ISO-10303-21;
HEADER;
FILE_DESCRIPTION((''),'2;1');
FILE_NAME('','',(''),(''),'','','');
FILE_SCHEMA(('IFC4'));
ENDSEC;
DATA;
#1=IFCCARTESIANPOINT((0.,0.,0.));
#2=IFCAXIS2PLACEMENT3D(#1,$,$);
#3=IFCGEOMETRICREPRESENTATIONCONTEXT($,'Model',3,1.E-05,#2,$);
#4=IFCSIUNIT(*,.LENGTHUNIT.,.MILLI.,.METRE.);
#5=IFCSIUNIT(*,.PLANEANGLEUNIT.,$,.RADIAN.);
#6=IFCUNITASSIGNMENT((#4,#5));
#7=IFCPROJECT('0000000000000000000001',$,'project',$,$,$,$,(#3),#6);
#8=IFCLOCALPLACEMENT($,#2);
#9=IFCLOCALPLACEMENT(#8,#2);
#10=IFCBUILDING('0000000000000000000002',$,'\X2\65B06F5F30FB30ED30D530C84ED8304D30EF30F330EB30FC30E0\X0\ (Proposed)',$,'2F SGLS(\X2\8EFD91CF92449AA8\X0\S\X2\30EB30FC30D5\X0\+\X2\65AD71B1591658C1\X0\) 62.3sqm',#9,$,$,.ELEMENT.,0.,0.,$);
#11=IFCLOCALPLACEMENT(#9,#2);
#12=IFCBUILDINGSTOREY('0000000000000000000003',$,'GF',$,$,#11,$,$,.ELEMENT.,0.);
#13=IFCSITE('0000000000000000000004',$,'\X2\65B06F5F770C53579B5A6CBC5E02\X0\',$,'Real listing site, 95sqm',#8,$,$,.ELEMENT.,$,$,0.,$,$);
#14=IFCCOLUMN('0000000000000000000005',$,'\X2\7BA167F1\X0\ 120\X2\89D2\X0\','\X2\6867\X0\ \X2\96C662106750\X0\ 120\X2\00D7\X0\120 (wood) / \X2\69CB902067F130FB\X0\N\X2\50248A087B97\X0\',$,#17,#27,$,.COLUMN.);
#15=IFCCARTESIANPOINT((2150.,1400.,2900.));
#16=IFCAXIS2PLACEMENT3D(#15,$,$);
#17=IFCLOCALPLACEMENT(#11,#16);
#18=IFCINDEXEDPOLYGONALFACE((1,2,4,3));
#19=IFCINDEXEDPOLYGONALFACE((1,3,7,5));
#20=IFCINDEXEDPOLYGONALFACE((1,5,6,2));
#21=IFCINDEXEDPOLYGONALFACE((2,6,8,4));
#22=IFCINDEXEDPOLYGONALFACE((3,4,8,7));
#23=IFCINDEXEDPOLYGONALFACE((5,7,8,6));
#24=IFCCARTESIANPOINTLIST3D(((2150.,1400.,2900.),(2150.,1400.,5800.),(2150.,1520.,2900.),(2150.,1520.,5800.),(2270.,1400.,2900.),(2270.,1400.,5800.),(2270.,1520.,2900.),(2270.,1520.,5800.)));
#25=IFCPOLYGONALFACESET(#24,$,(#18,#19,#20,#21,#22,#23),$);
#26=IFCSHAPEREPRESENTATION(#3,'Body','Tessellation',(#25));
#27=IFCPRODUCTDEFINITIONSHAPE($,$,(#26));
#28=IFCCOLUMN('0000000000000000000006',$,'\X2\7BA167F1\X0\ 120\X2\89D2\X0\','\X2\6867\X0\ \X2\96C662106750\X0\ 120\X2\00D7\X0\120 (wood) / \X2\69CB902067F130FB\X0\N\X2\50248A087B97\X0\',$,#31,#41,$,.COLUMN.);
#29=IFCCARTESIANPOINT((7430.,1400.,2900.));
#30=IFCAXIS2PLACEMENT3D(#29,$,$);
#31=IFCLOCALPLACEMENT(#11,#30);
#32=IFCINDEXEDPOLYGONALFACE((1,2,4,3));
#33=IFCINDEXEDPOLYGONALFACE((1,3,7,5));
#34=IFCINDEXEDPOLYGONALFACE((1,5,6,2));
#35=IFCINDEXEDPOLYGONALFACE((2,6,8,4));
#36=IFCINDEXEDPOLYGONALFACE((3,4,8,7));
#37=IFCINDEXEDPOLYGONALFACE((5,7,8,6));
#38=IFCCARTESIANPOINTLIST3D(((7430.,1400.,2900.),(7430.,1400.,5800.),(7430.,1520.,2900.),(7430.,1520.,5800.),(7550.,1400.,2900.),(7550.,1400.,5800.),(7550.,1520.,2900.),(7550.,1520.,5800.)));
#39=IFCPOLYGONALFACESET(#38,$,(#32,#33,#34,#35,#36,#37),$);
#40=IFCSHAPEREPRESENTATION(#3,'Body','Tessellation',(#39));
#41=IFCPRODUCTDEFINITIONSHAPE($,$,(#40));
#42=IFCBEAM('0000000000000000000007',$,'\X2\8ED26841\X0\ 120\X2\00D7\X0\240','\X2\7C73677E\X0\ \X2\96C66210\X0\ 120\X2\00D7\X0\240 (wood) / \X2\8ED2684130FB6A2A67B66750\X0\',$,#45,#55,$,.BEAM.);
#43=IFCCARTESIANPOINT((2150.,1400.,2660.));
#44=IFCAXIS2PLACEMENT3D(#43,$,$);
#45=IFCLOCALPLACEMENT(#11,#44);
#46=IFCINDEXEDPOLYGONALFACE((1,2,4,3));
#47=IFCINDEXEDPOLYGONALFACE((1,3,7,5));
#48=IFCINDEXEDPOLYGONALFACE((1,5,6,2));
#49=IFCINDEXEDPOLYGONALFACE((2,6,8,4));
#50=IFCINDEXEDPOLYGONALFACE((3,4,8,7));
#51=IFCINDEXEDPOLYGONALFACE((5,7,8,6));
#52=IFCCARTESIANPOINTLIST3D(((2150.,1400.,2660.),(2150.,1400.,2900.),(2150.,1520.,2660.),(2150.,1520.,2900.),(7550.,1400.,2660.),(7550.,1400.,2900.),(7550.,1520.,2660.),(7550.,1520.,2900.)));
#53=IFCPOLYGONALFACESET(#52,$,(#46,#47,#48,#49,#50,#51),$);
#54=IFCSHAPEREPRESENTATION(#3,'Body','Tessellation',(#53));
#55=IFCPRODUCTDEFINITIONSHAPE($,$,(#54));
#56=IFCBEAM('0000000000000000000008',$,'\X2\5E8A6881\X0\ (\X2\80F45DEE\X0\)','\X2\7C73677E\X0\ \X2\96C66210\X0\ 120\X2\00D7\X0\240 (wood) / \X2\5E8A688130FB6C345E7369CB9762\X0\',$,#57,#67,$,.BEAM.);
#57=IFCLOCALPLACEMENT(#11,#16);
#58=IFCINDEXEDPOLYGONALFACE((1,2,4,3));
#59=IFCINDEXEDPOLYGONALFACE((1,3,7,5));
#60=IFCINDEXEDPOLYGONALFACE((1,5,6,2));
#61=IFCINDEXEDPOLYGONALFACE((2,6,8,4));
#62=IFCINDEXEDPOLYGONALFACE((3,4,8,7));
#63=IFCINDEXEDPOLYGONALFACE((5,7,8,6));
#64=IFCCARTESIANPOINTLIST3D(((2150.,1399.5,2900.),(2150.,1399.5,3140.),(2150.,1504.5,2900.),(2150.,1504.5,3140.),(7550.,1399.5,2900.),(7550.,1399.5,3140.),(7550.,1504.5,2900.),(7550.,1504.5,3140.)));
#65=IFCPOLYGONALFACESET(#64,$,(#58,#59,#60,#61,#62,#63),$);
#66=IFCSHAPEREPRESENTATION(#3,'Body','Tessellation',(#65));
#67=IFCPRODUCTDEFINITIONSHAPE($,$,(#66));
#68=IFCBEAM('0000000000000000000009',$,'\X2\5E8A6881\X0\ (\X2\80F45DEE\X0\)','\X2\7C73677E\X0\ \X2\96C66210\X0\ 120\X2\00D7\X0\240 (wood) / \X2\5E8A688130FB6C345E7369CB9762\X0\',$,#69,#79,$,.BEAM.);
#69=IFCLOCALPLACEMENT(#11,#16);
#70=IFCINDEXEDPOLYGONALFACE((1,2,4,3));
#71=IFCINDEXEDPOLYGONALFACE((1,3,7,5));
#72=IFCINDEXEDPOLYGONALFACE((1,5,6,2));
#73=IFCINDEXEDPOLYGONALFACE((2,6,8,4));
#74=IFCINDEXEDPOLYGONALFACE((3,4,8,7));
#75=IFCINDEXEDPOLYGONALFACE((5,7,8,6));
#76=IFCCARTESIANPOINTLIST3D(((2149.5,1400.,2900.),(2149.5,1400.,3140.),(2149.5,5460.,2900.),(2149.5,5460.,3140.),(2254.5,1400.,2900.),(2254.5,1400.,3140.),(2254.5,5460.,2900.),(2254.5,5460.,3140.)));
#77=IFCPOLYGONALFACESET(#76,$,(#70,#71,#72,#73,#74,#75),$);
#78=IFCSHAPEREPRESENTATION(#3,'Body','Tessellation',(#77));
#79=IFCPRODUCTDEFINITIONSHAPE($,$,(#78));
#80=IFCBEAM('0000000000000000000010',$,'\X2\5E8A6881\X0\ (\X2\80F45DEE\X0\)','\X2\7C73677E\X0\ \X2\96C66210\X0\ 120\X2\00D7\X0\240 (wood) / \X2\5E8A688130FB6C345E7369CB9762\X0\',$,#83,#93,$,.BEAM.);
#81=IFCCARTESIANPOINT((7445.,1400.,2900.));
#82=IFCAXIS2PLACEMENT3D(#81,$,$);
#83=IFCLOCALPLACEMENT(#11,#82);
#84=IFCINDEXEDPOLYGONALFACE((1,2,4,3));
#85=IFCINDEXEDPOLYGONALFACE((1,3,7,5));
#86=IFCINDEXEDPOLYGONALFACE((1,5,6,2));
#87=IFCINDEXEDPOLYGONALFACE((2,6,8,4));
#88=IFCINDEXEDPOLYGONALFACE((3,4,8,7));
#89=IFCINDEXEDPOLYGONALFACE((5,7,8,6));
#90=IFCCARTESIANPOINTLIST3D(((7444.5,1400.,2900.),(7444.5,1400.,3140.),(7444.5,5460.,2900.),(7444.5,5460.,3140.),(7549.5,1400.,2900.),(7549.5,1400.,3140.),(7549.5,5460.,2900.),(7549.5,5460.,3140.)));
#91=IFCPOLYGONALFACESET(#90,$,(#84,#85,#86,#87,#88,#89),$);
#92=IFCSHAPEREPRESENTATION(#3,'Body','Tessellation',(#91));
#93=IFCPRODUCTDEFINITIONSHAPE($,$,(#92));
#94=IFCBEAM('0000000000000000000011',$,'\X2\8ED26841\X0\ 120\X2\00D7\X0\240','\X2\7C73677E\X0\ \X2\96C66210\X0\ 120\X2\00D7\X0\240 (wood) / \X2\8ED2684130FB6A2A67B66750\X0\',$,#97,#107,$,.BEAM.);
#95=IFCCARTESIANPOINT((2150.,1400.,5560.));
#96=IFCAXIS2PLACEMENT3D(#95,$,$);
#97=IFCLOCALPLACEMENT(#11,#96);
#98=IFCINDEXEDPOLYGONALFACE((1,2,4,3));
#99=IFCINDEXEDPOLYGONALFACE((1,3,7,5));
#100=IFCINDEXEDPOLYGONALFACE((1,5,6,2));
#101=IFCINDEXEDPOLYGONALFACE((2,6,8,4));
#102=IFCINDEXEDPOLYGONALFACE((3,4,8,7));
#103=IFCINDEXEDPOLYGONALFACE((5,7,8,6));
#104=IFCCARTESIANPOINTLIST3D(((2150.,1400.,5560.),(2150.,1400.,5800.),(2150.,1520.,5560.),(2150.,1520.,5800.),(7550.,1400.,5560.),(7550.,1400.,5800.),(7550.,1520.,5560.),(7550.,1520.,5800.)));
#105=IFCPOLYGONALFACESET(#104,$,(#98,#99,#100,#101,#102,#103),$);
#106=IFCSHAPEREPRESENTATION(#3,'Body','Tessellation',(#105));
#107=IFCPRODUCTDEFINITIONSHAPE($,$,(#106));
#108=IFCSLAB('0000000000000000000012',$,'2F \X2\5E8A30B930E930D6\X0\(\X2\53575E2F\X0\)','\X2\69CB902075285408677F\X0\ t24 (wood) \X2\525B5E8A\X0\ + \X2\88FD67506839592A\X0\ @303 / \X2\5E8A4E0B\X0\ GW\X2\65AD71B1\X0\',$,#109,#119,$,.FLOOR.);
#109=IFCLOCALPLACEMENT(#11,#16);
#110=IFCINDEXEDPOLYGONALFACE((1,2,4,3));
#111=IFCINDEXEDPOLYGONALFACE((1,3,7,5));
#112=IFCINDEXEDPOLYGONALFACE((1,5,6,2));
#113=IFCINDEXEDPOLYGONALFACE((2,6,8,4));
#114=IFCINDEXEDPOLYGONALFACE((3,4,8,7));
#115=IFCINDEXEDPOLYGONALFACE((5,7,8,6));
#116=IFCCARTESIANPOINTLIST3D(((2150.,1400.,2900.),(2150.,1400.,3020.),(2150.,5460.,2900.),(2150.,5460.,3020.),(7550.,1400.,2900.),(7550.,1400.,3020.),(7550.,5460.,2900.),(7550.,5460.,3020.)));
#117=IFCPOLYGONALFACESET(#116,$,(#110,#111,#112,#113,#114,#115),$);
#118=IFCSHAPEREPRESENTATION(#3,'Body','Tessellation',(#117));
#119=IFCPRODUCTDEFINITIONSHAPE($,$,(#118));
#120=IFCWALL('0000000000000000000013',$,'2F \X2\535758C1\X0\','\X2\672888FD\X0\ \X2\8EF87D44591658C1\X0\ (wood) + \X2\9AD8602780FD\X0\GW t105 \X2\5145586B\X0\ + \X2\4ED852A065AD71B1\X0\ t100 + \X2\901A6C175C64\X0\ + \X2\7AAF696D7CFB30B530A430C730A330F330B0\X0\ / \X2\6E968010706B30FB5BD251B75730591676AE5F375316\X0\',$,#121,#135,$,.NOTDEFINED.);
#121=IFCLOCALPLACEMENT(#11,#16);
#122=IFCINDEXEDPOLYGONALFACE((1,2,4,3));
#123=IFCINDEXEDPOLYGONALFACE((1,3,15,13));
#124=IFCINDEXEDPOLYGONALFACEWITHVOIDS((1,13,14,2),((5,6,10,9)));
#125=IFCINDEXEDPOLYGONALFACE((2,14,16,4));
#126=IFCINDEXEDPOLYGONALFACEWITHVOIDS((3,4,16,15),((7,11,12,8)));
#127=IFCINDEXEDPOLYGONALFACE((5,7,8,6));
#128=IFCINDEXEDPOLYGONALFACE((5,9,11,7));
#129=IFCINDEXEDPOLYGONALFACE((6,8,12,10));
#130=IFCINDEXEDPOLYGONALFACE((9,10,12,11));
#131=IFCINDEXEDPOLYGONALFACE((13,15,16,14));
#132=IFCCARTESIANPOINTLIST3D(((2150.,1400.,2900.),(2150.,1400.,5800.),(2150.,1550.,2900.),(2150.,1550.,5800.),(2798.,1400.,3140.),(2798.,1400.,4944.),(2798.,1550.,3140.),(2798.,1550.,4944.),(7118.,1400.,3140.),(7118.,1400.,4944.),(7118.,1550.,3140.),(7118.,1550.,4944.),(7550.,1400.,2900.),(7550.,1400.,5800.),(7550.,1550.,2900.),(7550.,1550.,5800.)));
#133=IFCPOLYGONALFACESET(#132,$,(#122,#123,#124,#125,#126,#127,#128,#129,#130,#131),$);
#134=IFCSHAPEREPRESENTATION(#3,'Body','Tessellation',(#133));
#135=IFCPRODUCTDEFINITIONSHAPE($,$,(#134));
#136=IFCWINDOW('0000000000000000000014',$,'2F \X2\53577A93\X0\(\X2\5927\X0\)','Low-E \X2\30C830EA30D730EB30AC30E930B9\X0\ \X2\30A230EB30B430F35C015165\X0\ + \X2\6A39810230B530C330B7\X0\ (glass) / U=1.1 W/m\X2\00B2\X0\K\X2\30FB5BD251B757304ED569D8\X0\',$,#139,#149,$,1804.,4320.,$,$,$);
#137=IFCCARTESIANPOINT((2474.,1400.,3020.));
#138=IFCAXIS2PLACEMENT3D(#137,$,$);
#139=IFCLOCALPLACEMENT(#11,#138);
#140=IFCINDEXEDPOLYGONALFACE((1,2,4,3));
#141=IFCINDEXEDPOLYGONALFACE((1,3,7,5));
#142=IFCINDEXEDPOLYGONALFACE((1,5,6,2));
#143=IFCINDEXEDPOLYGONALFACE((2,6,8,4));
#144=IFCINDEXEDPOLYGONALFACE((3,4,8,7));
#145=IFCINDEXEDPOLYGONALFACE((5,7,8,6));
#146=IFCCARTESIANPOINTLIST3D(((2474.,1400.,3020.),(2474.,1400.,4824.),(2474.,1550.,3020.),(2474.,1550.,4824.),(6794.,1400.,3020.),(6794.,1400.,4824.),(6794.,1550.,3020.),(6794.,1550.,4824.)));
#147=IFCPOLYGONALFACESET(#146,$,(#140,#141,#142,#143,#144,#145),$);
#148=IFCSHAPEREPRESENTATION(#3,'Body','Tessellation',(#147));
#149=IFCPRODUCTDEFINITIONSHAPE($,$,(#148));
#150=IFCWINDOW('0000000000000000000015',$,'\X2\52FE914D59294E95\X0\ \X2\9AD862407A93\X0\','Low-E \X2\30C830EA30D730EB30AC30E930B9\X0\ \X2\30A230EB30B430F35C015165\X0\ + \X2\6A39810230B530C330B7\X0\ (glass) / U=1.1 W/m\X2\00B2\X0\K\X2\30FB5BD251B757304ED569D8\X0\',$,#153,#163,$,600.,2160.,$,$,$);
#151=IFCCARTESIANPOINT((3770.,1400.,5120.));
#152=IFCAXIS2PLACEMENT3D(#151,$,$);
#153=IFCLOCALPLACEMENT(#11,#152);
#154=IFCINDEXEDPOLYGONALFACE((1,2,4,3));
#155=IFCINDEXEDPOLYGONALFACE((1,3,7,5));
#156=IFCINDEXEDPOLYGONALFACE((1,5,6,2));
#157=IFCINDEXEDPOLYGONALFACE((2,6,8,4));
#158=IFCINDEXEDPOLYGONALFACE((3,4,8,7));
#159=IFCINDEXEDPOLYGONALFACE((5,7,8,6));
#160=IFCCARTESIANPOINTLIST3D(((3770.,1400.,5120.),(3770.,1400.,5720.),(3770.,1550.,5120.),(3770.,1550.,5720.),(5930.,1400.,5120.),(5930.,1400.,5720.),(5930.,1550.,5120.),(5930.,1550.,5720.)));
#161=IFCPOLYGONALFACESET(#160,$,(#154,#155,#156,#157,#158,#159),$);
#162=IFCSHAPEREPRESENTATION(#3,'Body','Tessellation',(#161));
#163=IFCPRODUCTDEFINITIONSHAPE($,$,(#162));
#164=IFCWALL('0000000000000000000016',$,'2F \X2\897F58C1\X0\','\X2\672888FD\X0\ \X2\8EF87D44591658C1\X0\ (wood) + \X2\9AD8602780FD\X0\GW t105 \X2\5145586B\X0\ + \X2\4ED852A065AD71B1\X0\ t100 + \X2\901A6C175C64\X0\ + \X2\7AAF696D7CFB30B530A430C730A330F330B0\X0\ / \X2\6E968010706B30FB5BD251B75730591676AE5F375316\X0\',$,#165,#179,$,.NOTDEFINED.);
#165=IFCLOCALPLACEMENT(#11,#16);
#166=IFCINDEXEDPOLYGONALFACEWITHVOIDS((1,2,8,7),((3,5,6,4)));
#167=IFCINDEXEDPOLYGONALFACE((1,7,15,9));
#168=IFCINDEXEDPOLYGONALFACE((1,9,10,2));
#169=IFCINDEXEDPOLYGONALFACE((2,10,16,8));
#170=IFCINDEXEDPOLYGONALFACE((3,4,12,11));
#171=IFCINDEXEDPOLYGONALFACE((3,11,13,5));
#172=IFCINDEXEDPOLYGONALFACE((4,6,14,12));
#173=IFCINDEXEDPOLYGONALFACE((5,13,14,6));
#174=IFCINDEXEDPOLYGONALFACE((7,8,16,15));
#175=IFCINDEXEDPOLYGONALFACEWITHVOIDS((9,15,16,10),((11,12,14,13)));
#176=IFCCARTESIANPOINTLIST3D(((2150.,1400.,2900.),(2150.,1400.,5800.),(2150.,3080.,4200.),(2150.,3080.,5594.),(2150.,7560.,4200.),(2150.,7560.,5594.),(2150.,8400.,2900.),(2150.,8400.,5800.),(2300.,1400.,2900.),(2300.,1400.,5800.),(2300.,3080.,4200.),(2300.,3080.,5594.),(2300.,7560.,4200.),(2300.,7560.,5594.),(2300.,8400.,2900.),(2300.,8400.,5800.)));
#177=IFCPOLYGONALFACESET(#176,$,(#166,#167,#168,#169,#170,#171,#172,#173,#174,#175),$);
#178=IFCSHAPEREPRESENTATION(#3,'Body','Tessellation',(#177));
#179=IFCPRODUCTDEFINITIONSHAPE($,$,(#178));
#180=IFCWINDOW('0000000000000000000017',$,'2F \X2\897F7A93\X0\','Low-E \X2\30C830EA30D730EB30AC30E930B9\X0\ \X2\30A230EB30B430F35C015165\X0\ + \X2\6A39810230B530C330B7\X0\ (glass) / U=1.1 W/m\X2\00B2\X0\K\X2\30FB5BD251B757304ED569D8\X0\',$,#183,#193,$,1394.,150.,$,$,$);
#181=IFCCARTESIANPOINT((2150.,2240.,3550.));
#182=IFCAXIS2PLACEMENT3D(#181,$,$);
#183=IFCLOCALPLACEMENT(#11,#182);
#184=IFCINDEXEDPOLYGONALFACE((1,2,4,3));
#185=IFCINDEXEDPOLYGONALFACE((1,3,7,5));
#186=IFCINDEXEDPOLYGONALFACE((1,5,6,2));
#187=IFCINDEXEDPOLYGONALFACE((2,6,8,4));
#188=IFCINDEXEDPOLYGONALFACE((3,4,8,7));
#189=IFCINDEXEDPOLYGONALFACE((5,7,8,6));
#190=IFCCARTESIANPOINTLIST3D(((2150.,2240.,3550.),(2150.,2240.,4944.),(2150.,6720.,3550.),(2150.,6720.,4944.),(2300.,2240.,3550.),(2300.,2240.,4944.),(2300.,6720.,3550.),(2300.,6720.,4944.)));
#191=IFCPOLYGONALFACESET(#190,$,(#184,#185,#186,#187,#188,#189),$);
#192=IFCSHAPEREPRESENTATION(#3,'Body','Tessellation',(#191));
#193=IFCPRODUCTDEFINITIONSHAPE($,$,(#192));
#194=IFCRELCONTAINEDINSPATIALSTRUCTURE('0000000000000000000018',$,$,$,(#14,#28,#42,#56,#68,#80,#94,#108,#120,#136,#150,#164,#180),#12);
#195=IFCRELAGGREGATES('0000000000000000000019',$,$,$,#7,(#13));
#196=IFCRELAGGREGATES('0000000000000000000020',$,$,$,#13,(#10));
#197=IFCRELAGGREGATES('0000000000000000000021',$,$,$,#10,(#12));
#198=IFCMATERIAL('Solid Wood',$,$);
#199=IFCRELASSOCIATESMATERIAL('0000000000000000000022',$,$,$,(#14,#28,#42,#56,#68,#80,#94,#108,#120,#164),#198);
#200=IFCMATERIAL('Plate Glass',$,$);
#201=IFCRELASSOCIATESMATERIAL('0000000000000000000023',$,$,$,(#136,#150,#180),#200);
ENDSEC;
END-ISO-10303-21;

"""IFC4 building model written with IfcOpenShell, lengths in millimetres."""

from ifc_helpers import new_model, si_unit, frame, frame_2d, origin, place, context, project, spatial, rectangle, extrude, material, element, fill, save


model = new_model("IFC4")

# Units and contexts
model_context = context("Model", 3, precision=1e-05, world=origin())
ifc_project = project(units=[si_unit("LENGTHUNIT", "METRE", prefix="MILLI"), si_unit("PLANEANGLEUNIT", "RADIAN")], contexts=[model_context])

# Site, building, storey
site_placement = place(None, origin())
site = spatial("IfcSite", under=ifc_project, at=site_placement, Name="新潟県南魚沼市", ObjectType="Real listing site, 95sqm", CompositionType="ELEMENT", RefElevation=0.0)
building_placement = place(site_placement, origin())
building = spatial("IfcBuilding", under=site, at=building_placement, Name="新潟・ロフト付きワンルーム (Proposed)", ObjectType="2F SGLS(軽量鉄骨Sルーフ+断熱外壁) 62.3sqm", CompositionType="ELEMENT", ElevationOfRefHeight=0.0, ElevationOfTerrain=0.0)
storey_placement = place(building_placement, origin())
storey = spatial("IfcBuildingStorey", under=building, at=storey_placement, Name="GF", CompositionType="ELEMENT", Elevation=0.0)

# Columns
ifc_material_1 = material(Name="Solid Wood")
column_1_placement = place(storey_placement, frame((2150.0, 1400.0, 2900.0)))
element("IfcColumn", 1, at=column_1_placement, inside=storey, material=ifc_material_1, Name="管柱 120角", Description="桧 集成材 120×120 (wood) / 構造柱・N値計算", PredefinedType="COLUMN", context=model_context, shape_type="SweptSolid", body=[
    extrude(rectangle(XDim=120.0, YDim=120.0, at=frame_2d((60.0, 60.0))), frame((2150.0, 1400.0, 2900.0)), (0.0, 0.0, 1.0), 2900.0),
])
column_2_placement = place(storey_placement, frame((7430.0, 1400.0, 2900.0)))
element("IfcColumn", 2, at=column_2_placement, inside=storey, material=ifc_material_1, Name="管柱 120角", Description="桧 集成材 120×120 (wood) / 構造柱・N値計算", PredefinedType="COLUMN", context=model_context, shape_type="SweptSolid", body=[
    extrude(rectangle(XDim=120.0, YDim=120.0, at=frame_2d((60.0, 60.0))), frame((7430.0, 1400.0, 2900.0)), (0.0, 0.0, 1.0), 2900.0),
])

# Beams
beam_1_placement = place(storey_placement, frame((2150.0, 1400.0, 2660.0)))
element("IfcBeam", 3, at=beam_1_placement, inside=storey, material=ifc_material_1, Name="軒桁 120×240", Description="米松 集成 120×240 (wood) / 軒桁・横架材", PredefinedType="BEAM", context=model_context, shape_type="SweptSolid", body=[
    extrude(rectangle(XDim=5400.0, YDim=120.0, at=frame_2d((2700.0, 60.0))), frame((2150.0, 1400.0, 2660.0)), (0.0, 0.0, 1.0), 240.0),
])
beam_2_placement = place(storey_placement, frame((2150.0, 1400.0, 2900.0)))
element("IfcBeam", 4, at=beam_2_placement, inside=storey, material=ifc_material_1, Name="床梁 (胴差)", Description="米松 集成 120×240 (wood) / 床梁・水平構面", PredefinedType="BEAM", context=model_context, shape_type="SweptSolid", body=[
    extrude(rectangle(XDim=5400.0, YDim=105.0, at=frame_2d((2700.0, 52.0))), frame((2150.0, 1400.0, 2900.0)), (0.0, 0.0, 1.0), 240.0),
])
beam_3_placement = place(storey_placement, frame((2150.0, 1400.0, 2900.0)))
element("IfcBeam", 5, at=beam_3_placement, inside=storey, material=ifc_material_1, Name="床梁 (胴差)", Description="米松 集成 120×240 (wood) / 床梁・水平構面", PredefinedType="BEAM", context=model_context, shape_type="SweptSolid", body=[
    extrude(rectangle(XDim=105.0, YDim=4060.0, at=frame_2d((52.0, 2030.0))), frame((2150.0, 1400.0, 2900.0)), (0.0, 0.0, 1.0), 240.0),
])
beam_4_placement = place(storey_placement, frame((7445.0, 1400.0, 2900.0)))
element("IfcBeam", 6, at=beam_4_placement, inside=storey, material=ifc_material_1, Name="床梁 (胴差)", Description="米松 集成 120×240 (wood) / 床梁・水平構面", PredefinedType="BEAM", context=model_context, shape_type="SweptSolid", body=[
    extrude(rectangle(XDim=105.0, YDim=4060.0, at=frame_2d((52.0, 2030.0))), frame((7445.0, 1400.0, 2900.0)), (0.0, 0.0, 1.0), 240.0),
])
beam_5_placement = place(storey_placement, frame((2150.0, 1400.0, 5560.0)))
element("IfcBeam", 7, at=beam_5_placement, inside=storey, material=ifc_material_1, Name="軒桁 120×240", Description="米松 集成 120×240 (wood) / 軒桁・横架材", PredefinedType="BEAM", context=model_context, shape_type="SweptSolid", body=[
    extrude(rectangle(XDim=5400.0, YDim=120.0, at=frame_2d((2700.0, 60.0))), frame((2150.0, 1400.0, 5560.0)), (0.0, 0.0, 1.0), 240.0),
])

# Slab
slab_placement = place(storey_placement, frame((2150.0, 1400.0, 2900.0)))
element("IfcSlab", 8, at=slab_placement, inside=storey, material=ifc_material_1, Name="2F 床スラブ(南帯)", Description="構造用合板 t24 (wood) 剛床 + 製材根太 @303 / 床下 GW断熱", PredefinedType="FLOOR", context=model_context, shape_type="SweptSolid", body=[
    extrude(rectangle(XDim=5400.0, YDim=4060.0, at=frame_2d((2700.0, 2030.0))), frame((2150.0, 1400.0, 2900.0)), (0.0, 0.0, 1.0), 120.0),
])

# Wall, openings, windows
wall_1_placement = place(storey_placement, frame((2150.0, 1400.0, 2900.0)))
wall_1 = element("IfcWall", 9, at=wall_1_placement, inside=storey, material=ifc_material_1, Name="2F 南壁", Description="木製 軸組外壁 (wood) + 高性能GW t105 充填 + 付加断熱 t100 + 通気層 + 窯業系サイディング / 準耐火・寒冷地外皮強化", PredefinedType="NOTDEFINED", context=model_context, shape_type="SweptSolid", body=[
    extrude(rectangle(XDim=5400.0, YDim=150.0, at=frame_2d((2700.0, 75.0))), frame((2150.0, 1400.0, 2900.0)), (0.0, 0.0, 1.0), 2900.0),
])
opening_1_placement = place(storey_placement, frame((2474.0, 1400.0, 3020.0)))
opening_1 = element("IfcOpeningElement", 10, at=opening_1_placement, cuts=wall_1, PredefinedType="NOTDEFINED", context=model_context, shape_type="SweptSolid", body=[
    extrude(rectangle(XDim=4320.0, YDim=150.0, at=frame_2d((2160.0, 75.0))), frame((2474.0, 1400.0, 3020.0)), (0.0, 0.0, 1.0), 1804.0),
])
opening_2_placement = place(storey_placement, frame((3770.0, 1400.0, 5120.0)))
opening_2 = element("IfcOpeningElement", 11, at=opening_2_placement, cuts=wall_1, PredefinedType="NOTDEFINED", context=model_context, shape_type="SweptSolid", body=[
    extrude(rectangle(XDim=2160.0, YDim=150.0, at=frame_2d((1080.0, 75.0))), frame((3770.0, 1400.0, 5120.0)), (0.0, 0.0, 1.0), 600.0),
])
ifc_material_2 = material(Name="Plate Glass")
window_1_placement = place(storey_placement, frame((2474.0, 1400.0, 3020.0)))
window_1 = element("IfcWindow", 12, at=window_1_placement, inside=storey, material=ifc_material_2, Name="2F 南窓(大)", Description="Low-E トリプルガラス アルゴン封入 + 樹脂サッシ (glass) / U=1.1 W/m²K・寒冷地仕様", OverallHeight=1804.0, OverallWidth=4320.0, context=model_context, shape_type="SweptSolid", body=[
    extrude(rectangle(XDim=4320.0, YDim=150.0, at=frame_2d((2160.0, 75.0))), frame((2474.0, 1400.0, 3020.0)), (0.0, 0.0, 1.0), 1804.0),
])
fill(opening_1, window_1)
window_2_placement = place(storey_placement, frame((3770.0, 1400.0, 5120.0)))
window_2 = element("IfcWindow", 13, at=window_2_placement, inside=storey, material=ifc_material_2, Name="勾配天井 高所窓", Description="Low-E トリプルガラス アルゴン封入 + 樹脂サッシ (glass) / U=1.1 W/m²K・寒冷地仕様", OverallHeight=600.0, OverallWidth=2160.0, context=model_context, shape_type="SweptSolid", body=[
    extrude(rectangle(XDim=2160.0, YDim=150.0, at=frame_2d((1080.0, 75.0))), frame((3770.0, 1400.0, 5120.0)), (0.0, 0.0, 1.0), 600.0),
])
fill(opening_2, window_2)

# Wall, opening, window
wall_2_placement = place(storey_placement, frame((2150.0, 1400.0, 2900.0)))
wall_2 = element("IfcWall", 14, at=wall_2_placement, inside=storey, material=ifc_material_1, Name="2F 西壁", Description="木製 軸組外壁 (wood) + 高性能GW t105 充填 + 付加断熱 t100 + 通気層 + 窯業系サイディング / 準耐火・寒冷地外皮強化", PredefinedType="NOTDEFINED", context=model_context, shape_type="SweptSolid", body=[
    extrude(rectangle(XDim=150.0, YDim=7000.0, at=frame_2d((75.0, 3500.0))), frame((2150.0, 1400.0, 2900.0)), (0.0, 0.0, 1.0), 2900.0),
])
opening_3_placement = place(storey_placement, frame((2150.0, 2240.0, 3550.0)))
opening_3 = element("IfcOpeningElement", 15, at=opening_3_placement, cuts=wall_2, PredefinedType="NOTDEFINED", context=model_context, shape_type="SweptSolid", body=[
    extrude(rectangle(XDim=150.0, YDim=4480.0, at=frame_2d((75.0, 2240.0))), frame((2150.0, 2240.0, 3550.0)), (0.0, 0.0, 1.0), 1394.0),
])
window_3_placement = place(storey_placement, frame((2150.0, 2240.0, 3550.0)))
window_3 = element("IfcWindow", 16, at=window_3_placement, inside=storey, material=ifc_material_2, Name="2F 西窓", Description="Low-E トリプルガラス アルゴン封入 + 樹脂サッシ (glass) / U=1.1 W/m²K・寒冷地仕様", OverallHeight=1394.0, OverallWidth=150.0, context=model_context, shape_type="SweptSolid", body=[
    extrude(rectangle(XDim=150.0, YDim=4480.0, at=frame_2d((75.0, 2240.0))), frame((2150.0, 2240.0, 3550.0)), (0.0, 0.0, 1.0), 1394.0),
])
fill(opening_3, window_3)

save(model, "model.ifc")
